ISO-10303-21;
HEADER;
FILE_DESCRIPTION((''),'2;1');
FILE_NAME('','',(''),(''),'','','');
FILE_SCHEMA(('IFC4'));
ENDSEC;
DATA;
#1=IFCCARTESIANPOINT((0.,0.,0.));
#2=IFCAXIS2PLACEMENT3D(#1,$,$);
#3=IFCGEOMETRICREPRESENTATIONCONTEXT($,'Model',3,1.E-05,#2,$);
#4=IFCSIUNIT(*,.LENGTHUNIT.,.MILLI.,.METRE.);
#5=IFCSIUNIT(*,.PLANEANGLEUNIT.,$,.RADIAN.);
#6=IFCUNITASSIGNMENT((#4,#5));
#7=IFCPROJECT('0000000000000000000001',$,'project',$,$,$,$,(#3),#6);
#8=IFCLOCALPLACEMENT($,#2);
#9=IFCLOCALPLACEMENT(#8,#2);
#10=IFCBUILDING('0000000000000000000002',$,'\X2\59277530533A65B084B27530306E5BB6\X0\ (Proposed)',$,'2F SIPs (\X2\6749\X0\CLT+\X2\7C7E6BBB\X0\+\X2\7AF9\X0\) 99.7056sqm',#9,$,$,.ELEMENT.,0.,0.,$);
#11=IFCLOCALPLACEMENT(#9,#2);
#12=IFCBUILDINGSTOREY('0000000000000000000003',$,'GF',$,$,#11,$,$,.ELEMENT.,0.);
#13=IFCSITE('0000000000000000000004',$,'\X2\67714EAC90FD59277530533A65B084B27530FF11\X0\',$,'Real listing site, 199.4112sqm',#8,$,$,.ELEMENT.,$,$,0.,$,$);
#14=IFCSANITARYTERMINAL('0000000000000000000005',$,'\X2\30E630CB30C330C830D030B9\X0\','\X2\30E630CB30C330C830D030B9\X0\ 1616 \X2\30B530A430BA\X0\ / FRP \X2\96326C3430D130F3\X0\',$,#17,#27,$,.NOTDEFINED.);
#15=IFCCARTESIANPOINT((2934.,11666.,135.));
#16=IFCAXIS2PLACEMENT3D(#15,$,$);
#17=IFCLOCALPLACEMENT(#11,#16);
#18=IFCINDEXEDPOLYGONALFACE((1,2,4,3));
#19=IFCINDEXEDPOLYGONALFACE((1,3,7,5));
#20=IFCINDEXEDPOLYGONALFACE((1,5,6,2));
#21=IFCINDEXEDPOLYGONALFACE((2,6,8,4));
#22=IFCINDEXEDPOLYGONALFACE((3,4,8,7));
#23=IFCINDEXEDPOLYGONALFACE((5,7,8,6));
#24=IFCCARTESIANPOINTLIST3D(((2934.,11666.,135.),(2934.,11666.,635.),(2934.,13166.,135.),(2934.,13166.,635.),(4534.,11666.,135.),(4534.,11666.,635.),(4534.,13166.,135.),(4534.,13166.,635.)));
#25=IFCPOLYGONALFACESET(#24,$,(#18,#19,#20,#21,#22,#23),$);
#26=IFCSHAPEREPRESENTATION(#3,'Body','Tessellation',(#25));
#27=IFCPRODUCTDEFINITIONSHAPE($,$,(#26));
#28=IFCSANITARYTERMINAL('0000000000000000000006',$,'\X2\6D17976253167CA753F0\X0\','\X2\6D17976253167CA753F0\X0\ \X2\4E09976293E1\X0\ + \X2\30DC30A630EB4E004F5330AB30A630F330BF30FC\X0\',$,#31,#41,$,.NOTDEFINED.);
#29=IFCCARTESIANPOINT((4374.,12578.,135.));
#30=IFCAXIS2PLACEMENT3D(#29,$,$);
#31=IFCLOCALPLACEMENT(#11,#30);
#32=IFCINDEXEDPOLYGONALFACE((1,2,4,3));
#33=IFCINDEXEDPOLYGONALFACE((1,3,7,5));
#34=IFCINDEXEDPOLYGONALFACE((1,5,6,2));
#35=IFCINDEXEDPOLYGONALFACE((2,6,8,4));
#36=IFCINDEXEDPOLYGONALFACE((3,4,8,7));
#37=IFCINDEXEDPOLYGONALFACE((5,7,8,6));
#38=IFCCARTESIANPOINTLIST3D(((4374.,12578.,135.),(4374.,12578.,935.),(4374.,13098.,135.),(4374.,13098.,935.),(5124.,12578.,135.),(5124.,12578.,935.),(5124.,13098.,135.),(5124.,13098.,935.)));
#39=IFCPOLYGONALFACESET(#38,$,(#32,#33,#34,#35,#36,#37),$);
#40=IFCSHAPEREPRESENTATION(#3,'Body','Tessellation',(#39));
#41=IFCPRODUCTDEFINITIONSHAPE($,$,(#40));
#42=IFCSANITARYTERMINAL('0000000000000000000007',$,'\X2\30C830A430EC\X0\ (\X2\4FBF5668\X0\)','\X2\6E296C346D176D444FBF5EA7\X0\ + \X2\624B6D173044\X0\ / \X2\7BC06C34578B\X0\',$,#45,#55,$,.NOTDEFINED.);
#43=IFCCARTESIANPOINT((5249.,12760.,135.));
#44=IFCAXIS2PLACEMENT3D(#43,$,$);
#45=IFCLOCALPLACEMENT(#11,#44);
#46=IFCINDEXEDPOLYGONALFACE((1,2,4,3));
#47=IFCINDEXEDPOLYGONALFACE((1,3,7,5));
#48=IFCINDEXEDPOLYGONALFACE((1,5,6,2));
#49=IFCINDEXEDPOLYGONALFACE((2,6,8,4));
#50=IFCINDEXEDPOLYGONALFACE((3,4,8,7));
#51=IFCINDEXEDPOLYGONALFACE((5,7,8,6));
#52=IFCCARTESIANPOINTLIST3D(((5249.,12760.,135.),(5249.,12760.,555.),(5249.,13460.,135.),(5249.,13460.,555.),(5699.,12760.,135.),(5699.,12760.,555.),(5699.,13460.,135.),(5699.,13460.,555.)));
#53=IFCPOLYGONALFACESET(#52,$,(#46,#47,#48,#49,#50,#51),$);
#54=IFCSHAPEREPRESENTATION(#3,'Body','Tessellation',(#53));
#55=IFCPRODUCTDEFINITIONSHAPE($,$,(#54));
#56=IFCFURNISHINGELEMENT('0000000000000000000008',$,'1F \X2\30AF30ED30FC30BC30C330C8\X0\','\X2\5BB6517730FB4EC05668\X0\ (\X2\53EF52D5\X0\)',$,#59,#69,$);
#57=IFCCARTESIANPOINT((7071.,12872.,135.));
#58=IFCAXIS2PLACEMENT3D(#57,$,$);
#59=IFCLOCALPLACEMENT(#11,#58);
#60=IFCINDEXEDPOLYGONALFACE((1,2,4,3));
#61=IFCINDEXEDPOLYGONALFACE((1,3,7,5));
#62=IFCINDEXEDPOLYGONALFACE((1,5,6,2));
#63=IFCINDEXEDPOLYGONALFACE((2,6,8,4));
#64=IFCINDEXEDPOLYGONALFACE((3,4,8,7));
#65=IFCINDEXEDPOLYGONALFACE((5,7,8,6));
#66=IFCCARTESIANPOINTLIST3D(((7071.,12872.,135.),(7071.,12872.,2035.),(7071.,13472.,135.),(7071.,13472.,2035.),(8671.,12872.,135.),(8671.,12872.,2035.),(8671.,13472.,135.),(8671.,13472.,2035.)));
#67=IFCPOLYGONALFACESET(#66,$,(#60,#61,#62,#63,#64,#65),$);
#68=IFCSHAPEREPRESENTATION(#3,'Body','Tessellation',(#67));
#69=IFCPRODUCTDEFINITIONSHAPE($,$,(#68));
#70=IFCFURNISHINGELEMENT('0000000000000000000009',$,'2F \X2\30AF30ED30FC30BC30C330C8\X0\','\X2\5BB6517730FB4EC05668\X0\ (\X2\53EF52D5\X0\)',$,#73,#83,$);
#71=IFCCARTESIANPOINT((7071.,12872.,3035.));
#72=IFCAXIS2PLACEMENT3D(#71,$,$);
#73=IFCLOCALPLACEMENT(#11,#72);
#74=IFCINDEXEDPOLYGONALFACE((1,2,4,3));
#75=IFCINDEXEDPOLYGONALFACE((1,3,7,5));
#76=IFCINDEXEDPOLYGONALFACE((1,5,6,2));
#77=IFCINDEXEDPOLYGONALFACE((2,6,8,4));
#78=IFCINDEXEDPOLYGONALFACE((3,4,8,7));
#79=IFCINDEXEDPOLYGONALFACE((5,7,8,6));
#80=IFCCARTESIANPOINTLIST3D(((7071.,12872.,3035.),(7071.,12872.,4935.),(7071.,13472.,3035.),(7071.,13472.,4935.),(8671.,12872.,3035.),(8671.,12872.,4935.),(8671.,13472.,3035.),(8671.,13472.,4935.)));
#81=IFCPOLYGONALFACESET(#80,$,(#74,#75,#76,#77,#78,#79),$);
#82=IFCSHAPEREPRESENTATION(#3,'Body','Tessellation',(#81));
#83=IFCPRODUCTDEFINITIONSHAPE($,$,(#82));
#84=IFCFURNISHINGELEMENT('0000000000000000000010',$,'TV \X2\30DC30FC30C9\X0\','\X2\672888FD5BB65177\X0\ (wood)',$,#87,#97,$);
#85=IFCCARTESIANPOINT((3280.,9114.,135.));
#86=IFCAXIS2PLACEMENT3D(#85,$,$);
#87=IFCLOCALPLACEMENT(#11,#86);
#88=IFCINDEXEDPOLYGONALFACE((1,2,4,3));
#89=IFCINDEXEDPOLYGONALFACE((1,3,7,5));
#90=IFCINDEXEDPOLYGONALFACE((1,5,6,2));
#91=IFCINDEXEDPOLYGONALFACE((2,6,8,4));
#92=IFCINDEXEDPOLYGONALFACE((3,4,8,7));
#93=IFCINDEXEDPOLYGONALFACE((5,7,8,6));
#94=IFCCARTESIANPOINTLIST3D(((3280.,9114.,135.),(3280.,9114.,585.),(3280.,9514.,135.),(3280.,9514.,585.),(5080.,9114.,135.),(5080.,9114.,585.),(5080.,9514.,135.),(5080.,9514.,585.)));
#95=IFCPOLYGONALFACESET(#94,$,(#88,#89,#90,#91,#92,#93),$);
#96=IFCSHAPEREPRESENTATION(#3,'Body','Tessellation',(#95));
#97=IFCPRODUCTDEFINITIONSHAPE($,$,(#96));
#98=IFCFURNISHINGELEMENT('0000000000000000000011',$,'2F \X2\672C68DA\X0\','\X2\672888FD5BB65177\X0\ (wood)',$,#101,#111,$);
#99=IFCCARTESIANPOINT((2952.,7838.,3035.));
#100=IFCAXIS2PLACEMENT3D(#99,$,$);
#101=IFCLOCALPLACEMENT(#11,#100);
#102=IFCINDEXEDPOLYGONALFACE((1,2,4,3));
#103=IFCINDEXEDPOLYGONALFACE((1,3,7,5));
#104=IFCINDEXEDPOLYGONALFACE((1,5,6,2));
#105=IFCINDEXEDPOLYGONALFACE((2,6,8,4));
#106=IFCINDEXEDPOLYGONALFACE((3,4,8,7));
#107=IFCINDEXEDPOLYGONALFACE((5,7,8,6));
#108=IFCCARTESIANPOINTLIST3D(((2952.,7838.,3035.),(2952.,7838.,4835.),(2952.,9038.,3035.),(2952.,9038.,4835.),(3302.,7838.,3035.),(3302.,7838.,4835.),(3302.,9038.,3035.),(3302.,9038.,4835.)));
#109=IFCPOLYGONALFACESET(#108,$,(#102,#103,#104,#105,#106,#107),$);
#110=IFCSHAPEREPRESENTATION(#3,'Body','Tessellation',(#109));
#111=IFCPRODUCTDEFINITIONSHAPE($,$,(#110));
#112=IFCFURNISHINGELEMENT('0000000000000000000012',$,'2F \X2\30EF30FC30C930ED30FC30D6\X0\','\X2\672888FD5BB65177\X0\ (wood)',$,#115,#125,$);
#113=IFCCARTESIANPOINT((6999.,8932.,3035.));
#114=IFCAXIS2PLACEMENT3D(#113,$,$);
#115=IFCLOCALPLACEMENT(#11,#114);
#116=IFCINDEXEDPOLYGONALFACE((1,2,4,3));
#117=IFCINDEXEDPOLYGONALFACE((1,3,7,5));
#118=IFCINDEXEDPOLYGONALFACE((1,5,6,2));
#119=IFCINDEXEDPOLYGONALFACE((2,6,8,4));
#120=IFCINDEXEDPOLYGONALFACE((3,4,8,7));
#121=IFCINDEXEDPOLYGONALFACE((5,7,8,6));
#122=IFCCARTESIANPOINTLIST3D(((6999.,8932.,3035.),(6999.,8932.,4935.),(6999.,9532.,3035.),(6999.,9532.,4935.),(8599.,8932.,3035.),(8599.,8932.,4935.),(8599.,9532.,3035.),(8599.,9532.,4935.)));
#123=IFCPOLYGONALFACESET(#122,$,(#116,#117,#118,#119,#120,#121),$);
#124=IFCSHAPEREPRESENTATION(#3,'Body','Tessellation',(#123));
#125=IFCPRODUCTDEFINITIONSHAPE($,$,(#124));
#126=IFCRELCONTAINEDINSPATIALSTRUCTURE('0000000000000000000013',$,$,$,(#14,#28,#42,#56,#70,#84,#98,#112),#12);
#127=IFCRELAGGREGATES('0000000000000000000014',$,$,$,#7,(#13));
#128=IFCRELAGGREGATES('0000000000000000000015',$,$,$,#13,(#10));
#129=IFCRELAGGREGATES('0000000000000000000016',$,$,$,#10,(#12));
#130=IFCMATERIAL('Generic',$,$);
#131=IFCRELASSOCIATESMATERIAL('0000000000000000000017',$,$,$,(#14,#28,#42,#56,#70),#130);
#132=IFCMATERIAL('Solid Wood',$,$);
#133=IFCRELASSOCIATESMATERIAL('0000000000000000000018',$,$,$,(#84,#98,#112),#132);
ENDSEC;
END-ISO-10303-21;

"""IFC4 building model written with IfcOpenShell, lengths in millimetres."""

from ifc_helpers import new_model, si_unit, frame, frame_2d, origin, place, context, project, spatial, rectangle, extrude, material, element, save


model = new_model("IFC4")

# Units and contexts
model_context = context("Model", 3, precision=1e-05, world=origin())
ifc_project = project(units=[si_unit("LENGTHUNIT", "METRE", prefix="MILLI"), si_unit("PLANEANGLEUNIT", "RADIAN")], contexts=[model_context])

# Site, building, storey
site_placement = place(None, origin())
site = spatial("IfcSite", under=ifc_project, at=site_placement, Name="東京都大田区新蒲田１", ObjectType="Real listing site, 199.4112sqm", CompositionType="ELEMENT", RefElevation=0.0)
building_placement = place(site_placement, origin())
building = spatial("IfcBuilding", under=site, at=building_placement, Name="大田区新蒲田の家 (Proposed)", ObjectType="2F SIPs (杉CLT+籾殻+竹) 99.7056sqm", CompositionType="ELEMENT", ElevationOfRefHeight=0.0, ElevationOfTerrain=0.0)
storey_placement = place(building_placement, origin())
storey = spatial("IfcBuildingStorey", under=building, at=storey_placement, Name="GF", CompositionType="ELEMENT", Elevation=0.0)

# Shared definitions
ifc_material_1 = material(Name="Solid Wood")

# Shared definitions
ifc_material_2 = material(Name="Generic")

# Sanitary terminals
sanitary_terminal_1_placement = place(storey_placement, frame((2934.0, 11666.0, 135.0)))
element("IfcSanitaryTerminal", 1, at=sanitary_terminal_1_placement, inside=storey, material=ifc_material_2, Name="ユニットバス", Description="ユニットバス 1616 サイズ / FRP 防水パン", PredefinedType="NOTDEFINED", context=model_context, shape_type="SweptSolid", body=[
    extrude(rectangle(XDim=1600.0, YDim=1500.0, at=frame_2d((800.0, 750.0))), frame((2934.0, 11666.0, 135.0)), (0.0, 0.0, 1.0), 500.0),
])
sanitary_terminal_2_placement = place(storey_placement, frame((4374.0, 12578.0, 135.0)))
element("IfcSanitaryTerminal", 2, at=sanitary_terminal_2_placement, inside=storey, material=ifc_material_2, Name="洗面化粧台", Description="洗面化粧台 三面鏡 + ボウル一体カウンター", PredefinedType="NOTDEFINED", context=model_context, shape_type="SweptSolid", body=[
    extrude(rectangle(XDim=750.0, YDim=520.0, at=frame_2d((375.0, 260.0))), frame((4374.0, 12578.0, 135.0)), (0.0, 0.0, 1.0), 800.0),
])
sanitary_terminal_3_placement = place(storey_placement, frame((5249.0, 12760.0, 135.0)))
element("IfcSanitaryTerminal", 3, at=sanitary_terminal_3_placement, inside=storey, material=ifc_material_2, Name="トイレ (便器)", Description="温水洗浄便座 + 手洗い / 節水型", PredefinedType="NOTDEFINED", context=model_context, shape_type="SweptSolid", body=[
    extrude(rectangle(XDim=450.0, YDim=700.0, at=frame_2d((225.0, 350.0))), frame((5249.0, 12760.0, 135.0)), (0.0, 0.0, 1.0), 420.0),
])

# Furnishing elements
furnishing_1_placement = place(storey_placement, frame((7071.0, 12872.0, 135.0)))
element("IfcFurnishingElement", 4, at=furnishing_1_placement, inside=storey, material=ifc_material_2, Name="1F クローゼット", Description="家具・什器 (可動)", context=model_context, shape_type="SweptSolid", body=[
    extrude(rectangle(XDim=1600.0, YDim=600.0, at=frame_2d((800.0, 300.0))), frame((7071.0, 12872.0, 135.0)), (0.0, 0.0, 1.0), 1900.0),
])
furnishing_2_placement = place(storey_placement, frame((7071.0, 12872.0, 3035.0)))
element("IfcFurnishingElement", 5, at=furnishing_2_placement, inside=storey, material=ifc_material_2, Name="2F クローゼット", Description="家具・什器 (可動)", context=model_context, shape_type="SweptSolid", body=[
    extrude(rectangle(XDim=1600.0, YDim=600.0, at=frame_2d((800.0, 300.0))), frame((7071.0, 12872.0, 3035.0)), (0.0, 0.0, 1.0), 1900.0),
])
furnishing_3_placement = place(storey_placement, frame((3280.0, 9114.0, 135.0)))
element("IfcFurnishingElement", 6, at=furnishing_3_placement, inside=storey, material=ifc_material_1, Name="TV ボード", Description="木製家具 (wood)", context=model_context, shape_type="SweptSolid", body=[
    extrude(rectangle(XDim=1800.0, YDim=400.0, at=frame_2d((900.0, 200.0))), frame((3280.0, 9114.0, 135.0)), (0.0, 0.0, 1.0), 450.0),
])
furnishing_4_placement = place(storey_placement, frame((2952.0, 7838.0, 3035.0)))
element("IfcFurnishingElement", 7, at=furnishing_4_placement, inside=storey, material=ifc_material_1, Name="2F 本棚", Description="木製家具 (wood)", context=model_context, shape_type="SweptSolid", body=[
    extrude(rectangle(XDim=350.0, YDim=1200.0, at=frame_2d((175.0, 600.0))), frame((2952.0, 7838.0, 3035.0)), (0.0, 0.0, 1.0), 1800.0),
])
furnishing_5_placement = place(storey_placement, frame((6999.0, 8932.0, 3035.0)))
element("IfcFurnishingElement", 8, at=furnishing_5_placement, inside=storey, material=ifc_material_1, Name="2F ワードローブ", Description="木製家具 (wood)", context=model_context, shape_type="SweptSolid", body=[
    extrude(rectangle(XDim=1600.0, YDim=600.0, at=frame_2d((800.0, 300.0))), frame((6999.0, 8932.0, 3035.0)), (0.0, 0.0, 1.0), 1900.0),
])

save(model, "model.ifc")
